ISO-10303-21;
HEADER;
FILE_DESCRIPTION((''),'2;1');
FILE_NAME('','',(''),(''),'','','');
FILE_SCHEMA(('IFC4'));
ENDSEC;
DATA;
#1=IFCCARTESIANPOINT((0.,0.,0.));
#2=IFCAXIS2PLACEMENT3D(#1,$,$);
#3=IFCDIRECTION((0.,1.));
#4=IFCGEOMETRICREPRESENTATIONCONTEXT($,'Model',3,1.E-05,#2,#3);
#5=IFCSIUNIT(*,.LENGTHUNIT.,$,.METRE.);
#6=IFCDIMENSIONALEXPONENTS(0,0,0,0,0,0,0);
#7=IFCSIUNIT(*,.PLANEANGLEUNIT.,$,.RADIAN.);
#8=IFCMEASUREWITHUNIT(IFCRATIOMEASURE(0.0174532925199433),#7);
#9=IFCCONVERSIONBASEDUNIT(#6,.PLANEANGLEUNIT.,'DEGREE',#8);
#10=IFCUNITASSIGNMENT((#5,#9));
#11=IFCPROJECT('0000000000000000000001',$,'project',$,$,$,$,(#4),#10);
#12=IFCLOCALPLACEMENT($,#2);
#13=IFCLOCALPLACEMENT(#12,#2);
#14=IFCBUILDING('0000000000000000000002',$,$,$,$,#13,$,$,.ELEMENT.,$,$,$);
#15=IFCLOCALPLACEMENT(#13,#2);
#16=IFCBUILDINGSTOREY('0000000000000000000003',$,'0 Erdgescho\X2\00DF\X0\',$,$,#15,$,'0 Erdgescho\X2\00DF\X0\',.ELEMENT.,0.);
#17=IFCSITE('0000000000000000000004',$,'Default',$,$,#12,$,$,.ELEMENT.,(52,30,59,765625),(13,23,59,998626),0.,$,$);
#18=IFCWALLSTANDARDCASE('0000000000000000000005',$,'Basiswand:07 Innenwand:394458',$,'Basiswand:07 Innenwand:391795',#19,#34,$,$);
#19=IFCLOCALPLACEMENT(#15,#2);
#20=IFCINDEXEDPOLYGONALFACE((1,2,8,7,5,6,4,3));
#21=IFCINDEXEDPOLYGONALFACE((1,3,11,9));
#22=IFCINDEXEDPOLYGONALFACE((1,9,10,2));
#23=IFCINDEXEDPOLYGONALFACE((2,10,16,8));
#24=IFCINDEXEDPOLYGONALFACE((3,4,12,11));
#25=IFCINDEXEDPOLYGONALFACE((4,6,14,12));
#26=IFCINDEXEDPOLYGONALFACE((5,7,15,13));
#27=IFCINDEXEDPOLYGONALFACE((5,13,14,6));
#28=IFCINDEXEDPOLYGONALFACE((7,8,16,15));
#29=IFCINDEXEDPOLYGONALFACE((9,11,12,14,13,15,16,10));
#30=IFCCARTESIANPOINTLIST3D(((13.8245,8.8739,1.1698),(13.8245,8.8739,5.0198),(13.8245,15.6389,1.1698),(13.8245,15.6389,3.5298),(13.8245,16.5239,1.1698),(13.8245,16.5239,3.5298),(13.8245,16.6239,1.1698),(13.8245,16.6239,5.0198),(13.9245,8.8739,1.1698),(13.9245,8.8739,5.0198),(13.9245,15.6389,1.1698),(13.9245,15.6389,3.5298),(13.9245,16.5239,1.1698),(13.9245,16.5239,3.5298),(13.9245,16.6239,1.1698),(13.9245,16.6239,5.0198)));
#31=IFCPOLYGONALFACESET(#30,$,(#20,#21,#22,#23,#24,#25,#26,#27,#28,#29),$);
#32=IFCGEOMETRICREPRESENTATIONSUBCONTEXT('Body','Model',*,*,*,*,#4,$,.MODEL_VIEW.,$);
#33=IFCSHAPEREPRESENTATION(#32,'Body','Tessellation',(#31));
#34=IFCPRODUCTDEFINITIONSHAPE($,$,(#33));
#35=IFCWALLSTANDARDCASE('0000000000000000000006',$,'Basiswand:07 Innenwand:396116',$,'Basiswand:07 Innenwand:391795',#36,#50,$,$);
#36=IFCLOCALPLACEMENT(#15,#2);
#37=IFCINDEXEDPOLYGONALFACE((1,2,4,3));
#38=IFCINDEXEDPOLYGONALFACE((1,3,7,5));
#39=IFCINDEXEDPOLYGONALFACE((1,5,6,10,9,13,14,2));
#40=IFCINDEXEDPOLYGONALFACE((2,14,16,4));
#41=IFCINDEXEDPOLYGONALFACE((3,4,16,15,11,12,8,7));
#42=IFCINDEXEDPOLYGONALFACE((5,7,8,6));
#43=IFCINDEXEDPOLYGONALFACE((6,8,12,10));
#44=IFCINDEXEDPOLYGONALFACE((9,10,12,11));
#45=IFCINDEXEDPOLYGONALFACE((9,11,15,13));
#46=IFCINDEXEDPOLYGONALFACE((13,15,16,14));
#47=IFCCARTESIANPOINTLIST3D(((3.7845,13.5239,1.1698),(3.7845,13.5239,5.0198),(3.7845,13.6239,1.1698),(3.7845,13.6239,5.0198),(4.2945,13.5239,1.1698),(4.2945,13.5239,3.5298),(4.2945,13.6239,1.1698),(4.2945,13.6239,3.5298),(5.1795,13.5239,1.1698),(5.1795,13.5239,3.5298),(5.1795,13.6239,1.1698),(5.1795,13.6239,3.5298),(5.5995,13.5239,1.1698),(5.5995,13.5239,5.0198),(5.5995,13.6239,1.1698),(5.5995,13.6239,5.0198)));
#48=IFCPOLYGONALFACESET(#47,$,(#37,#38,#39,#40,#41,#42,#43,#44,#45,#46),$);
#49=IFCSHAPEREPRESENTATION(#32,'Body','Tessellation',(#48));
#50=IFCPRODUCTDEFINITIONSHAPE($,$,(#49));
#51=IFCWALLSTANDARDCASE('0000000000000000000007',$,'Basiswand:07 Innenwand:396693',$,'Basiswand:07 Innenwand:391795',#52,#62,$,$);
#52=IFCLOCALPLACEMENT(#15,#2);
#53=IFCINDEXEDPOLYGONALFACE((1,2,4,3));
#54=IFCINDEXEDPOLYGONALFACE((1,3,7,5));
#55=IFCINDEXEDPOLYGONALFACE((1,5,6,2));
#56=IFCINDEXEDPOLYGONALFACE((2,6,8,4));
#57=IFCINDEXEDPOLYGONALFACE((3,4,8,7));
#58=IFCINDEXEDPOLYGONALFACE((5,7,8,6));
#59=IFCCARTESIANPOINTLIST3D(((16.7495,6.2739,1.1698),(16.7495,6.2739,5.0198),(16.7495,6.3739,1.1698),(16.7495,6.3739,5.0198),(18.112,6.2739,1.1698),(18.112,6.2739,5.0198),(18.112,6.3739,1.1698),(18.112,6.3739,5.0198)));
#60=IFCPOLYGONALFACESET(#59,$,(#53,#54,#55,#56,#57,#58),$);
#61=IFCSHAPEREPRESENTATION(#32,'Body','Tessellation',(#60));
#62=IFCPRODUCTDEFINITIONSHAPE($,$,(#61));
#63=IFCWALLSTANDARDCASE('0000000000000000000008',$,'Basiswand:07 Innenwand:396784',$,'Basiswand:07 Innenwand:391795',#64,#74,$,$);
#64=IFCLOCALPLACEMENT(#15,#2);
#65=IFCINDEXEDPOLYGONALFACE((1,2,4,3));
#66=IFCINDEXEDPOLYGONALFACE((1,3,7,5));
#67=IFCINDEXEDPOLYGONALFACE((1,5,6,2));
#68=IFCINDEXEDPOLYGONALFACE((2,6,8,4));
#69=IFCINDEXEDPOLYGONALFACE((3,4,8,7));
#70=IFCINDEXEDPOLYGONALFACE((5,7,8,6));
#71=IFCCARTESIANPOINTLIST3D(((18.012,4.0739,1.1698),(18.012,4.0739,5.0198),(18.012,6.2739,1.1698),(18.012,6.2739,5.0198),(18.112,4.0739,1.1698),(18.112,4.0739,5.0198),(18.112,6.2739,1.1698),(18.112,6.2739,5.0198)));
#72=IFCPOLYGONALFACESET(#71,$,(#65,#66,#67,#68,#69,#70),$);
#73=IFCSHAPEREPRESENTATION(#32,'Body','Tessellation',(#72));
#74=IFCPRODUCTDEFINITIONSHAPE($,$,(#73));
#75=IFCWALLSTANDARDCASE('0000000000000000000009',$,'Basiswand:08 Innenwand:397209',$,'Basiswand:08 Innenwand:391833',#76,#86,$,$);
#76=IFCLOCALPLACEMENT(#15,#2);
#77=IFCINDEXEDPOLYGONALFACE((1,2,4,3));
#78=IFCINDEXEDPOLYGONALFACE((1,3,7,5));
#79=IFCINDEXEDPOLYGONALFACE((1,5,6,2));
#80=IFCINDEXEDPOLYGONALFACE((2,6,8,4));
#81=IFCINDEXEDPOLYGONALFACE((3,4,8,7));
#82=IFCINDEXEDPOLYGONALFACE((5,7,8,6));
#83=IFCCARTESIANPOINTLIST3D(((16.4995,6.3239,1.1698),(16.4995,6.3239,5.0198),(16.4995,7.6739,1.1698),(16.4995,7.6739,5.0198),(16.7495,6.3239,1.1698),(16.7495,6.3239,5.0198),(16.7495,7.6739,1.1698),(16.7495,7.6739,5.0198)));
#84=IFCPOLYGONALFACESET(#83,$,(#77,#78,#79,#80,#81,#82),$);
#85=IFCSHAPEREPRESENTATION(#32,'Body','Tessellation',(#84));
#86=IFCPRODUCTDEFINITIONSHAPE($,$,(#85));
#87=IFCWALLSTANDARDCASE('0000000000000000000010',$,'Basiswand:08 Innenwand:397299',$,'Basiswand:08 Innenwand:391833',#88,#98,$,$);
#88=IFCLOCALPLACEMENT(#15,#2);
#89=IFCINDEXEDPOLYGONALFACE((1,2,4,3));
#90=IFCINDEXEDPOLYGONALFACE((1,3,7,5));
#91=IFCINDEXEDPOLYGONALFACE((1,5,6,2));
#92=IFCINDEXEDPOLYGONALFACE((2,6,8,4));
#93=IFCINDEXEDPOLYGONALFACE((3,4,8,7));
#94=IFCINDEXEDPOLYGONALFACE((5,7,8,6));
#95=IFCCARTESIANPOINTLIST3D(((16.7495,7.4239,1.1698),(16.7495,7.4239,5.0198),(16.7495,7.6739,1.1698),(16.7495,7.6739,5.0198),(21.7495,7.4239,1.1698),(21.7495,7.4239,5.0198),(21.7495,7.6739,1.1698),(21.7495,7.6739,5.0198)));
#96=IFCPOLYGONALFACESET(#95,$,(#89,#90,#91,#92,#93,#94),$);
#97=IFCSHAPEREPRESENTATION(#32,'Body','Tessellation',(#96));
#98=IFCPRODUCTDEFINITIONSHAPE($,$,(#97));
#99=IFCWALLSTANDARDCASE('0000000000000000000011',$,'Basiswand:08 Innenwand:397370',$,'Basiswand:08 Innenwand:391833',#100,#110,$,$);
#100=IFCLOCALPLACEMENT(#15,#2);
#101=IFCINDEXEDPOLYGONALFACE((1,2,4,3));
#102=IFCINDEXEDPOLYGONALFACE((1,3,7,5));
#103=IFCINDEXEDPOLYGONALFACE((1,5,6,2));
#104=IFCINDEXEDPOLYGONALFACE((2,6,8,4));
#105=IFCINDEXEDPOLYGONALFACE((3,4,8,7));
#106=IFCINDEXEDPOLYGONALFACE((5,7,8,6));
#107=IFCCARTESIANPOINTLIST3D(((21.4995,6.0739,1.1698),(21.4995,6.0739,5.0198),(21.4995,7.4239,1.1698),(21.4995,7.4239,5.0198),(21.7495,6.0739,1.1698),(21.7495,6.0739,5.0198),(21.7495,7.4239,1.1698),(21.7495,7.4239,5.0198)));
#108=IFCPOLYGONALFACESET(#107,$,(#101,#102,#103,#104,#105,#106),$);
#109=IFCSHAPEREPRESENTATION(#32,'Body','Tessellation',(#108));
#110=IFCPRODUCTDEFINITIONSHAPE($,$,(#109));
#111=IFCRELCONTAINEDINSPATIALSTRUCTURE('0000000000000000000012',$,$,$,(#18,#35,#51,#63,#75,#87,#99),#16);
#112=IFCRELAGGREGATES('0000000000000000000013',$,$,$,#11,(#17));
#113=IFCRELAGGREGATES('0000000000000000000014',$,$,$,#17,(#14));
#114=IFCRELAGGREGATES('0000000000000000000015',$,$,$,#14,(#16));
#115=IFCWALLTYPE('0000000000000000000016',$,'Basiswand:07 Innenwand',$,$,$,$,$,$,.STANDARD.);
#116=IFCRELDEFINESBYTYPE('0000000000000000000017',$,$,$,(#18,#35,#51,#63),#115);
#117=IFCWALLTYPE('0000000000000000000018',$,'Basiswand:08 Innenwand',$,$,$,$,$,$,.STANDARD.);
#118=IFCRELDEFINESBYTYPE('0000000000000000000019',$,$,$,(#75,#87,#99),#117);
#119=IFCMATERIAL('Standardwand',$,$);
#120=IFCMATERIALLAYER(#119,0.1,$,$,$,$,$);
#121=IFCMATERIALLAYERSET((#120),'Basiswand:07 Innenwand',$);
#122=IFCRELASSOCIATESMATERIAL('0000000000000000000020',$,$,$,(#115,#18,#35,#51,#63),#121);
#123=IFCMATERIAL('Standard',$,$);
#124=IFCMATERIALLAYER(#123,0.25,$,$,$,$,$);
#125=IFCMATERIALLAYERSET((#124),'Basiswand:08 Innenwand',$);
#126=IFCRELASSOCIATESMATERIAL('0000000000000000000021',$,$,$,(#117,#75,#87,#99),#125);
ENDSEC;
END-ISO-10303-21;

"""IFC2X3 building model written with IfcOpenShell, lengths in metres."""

from ifc_helpers import new_model, entity, si_unit, converted_unit, direction, frame, frame_2d, origin, place, context, subcontext, project, spatial, polyline, rectangle, extrude, clip, bounded_halfspace, material, layer, layer_set, layer_usage, type_object, element, save


model = new_model("IFC2X3")

# Units and contexts
model_context = context("Model", 3, precision=1e-05, world=origin(), true_north=direction((0.0, 1.0)))
body_context = subcontext(model_context, "Body", "Model", "MODEL_VIEW")
ifc_project = project(units=[si_unit("LENGTHUNIT", "METRE"), converted_unit("PLANEANGLEUNIT", "DEGREE", entity("IfcRatioMeasure", 0.0174532925199433), si_unit("PLANEANGLEUNIT", "RADIAN"), dimensions=[0, 0, 0, 0, 0, 0, 0])], contexts=[model_context])

# Site, building, storey
site_placement = place(None, origin())
site = spatial("IfcSite", under=ifc_project, at=site_placement, Name="Default", CompositionType="ELEMENT", RefLatitude=(52, 30, 59, 765625), RefLongitude=(13, 23, 59, 998626), RefElevation=0.0)
building_placement = place(site_placement, origin())
building = spatial("IfcBuilding", under=site, at=building_placement, CompositionType="ELEMENT")
storey_placement = place(building_placement, origin())
storey = spatial("IfcBuildingStorey", under=building, at=storey_placement, Name="0 Erdgeschoß", LongName="0 Erdgeschoß", CompositionType="ELEMENT", Elevation=0.0)

# Shared definitions
ifc_material_1 = material(Name="Standardwand")
ifc_layer_1 = layer(ifc_material_1, 0.1)
ifc_layer_set_1 = layer_set([ifc_layer_1], Name="Basiswand:07 Innenwand")
wall_type_1 = type_object("IfcWallType", Name="Basiswand:07 Innenwand", PredefinedType="STANDARD", material=ifc_layer_set_1)

# Walls, openings
ifc_layer_usage_1 = layer_usage(ifc_layer_set_1, "AXIS2", "NEGATIVE", 0.05)
wall_1_placement = place(storey_placement, frame((13.8745, 8.8739, 1.1698), z_axis=(0.0, 0.0, 1.0), x_axis=(0.0, 1.0, 0.0)))
wall_1 = element("IfcWallStandardCase", 1, at=wall_1_placement, inside=storey, type_object=wall_type_1, material=ifc_layer_usage_1, Name="Basiswand:07 Innenwand:394458", ObjectType="Basiswand:07 Innenwand:391795", context=body_context, shape_type="Clipping", body=[
    clip(extrude(rectangle(XDim=7.75, YDim=0.1, at=frame_2d((3.875, 0.0), x_axis=(-1.0, 0.0))), origin(), (0.0, 0.0, 1.0), 3.85), bounded_halfspace(frame((0.0, -0.05, 3.85), z_axis=(0.0, 0.0, -1.0), x_axis=(-1.0, 0.0, 0.0)), True, frame((0.0, -0.05, 3.85)), polyline([(0.0, 0.0), (7.75, 0.0), (7.75, 0.1), (0.0, 0.1), (0.0, 0.0)]))),
])
opening_1_placement = place(wall_1_placement, frame((6.765, -0.05, 0.0)))
element("IfcOpeningElement", 2, at=opening_1_placement, cuts=wall_1, ObjectType="Opening", context=body_context, shape_type="SweptSolid", body=[
    extrude(rectangle(XDim=2.36, YDim=0.885, at=frame_2d((1.18, 0.4425), x_axis=(1.0, 0.0))), frame((0.0, 0.0, 0.0), z_axis=(0.0, 1.0, 0.0), x_axis=(0.0, 0.0, 1.0)), (0.0, 0.0, 1.0), 0.1),
])
ifc_layer_usage_2 = layer_usage(ifc_layer_set_1, "AXIS2", "POSITIVE", -0.05)
wall_2_placement = place(storey_placement, frame((3.7845, 13.5739, 1.1698), z_axis=(0.0, 0.0, 1.0), x_axis=(1.0, 0.0, 0.0)))
wall_2 = element("IfcWallStandardCase", 3, at=wall_2_placement, inside=storey, type_object=wall_type_1, material=ifc_layer_usage_2, Name="Basiswand:07 Innenwand:396116", ObjectType="Basiswand:07 Innenwand:391795", context=body_context, shape_type="Clipping", body=[
    clip(extrude(rectangle(XDim=1.815, YDim=0.1, at=frame_2d((0.9075, 0.0), x_axis=(-1.0, 0.0))), origin(), (0.0, 0.0, 1.0), 3.85), bounded_halfspace(frame((0.0, -0.05, 3.85), z_axis=(0.0, 0.0, -1.0), x_axis=(0.0, -1.0, 0.0)), True, frame((0.0, -0.05, 3.85)), polyline([(0.0, 0.0), (1.815, 0.0), (1.815, 0.1), (0.0, 0.1), (0.0, 0.0)]))),
])
opening_2_placement = place(wall_2_placement, frame((1.395, 0.05, 0.0)))
element("IfcOpeningElement", 4, at=opening_2_placement, cuts=wall_2, ObjectType="Opening", context=body_context, shape_type="SweptSolid", body=[
    extrude(rectangle(XDim=2.36, YDim=0.885, at=frame_2d((1.18, 0.4425), x_axis=(1.0, 0.0))), frame((0.0, 0.0, 0.0), z_axis=(0.0, -1.0, 0.0), x_axis=(0.0, 0.0, 1.0)), (0.0, 0.0, 1.0), 0.1),
])

# Walls
ifc_layer_usage_3 = layer_usage(ifc_layer_set_1, "AXIS2", "POSITIVE", -0.05)
wall_3_placement = place(storey_placement, frame((16.7495, 6.3239, 1.1698), z_axis=(0.0, 0.0, 1.0), x_axis=(1.0, 0.0, 0.0)))
element("IfcWallStandardCase", 5, at=wall_3_placement, inside=storey, type_object=wall_type_1, material=ifc_layer_usage_3, Name="Basiswand:07 Innenwand:396693", ObjectType="Basiswand:07 Innenwand:391795", context=body_context, shape_type="Clipping", body=[
    clip(extrude(rectangle(XDim=1.3625, YDim=0.1, at=frame_2d((0.6813, 0.0), x_axis=(-1.0, 0.0))), origin(), (0.0, 0.0, 1.0), 3.85), bounded_halfspace(frame((0.0, -0.05, 3.85), z_axis=(0.0, 0.0, -1.0), x_axis=(0.0, -1.0, 0.0)), True, frame((0.0, -0.05, 3.85)), polyline([(0.0, 0.0), (1.2625, 0.0), (1.3625, 0.0), (1.3625, 0.1), (0.0, 0.1), (0.0, 0.05), (0.0, 0.0)]))),
])
ifc_layer_usage_4 = layer_usage(ifc_layer_set_1, "AXIS2", "POSITIVE", -0.05)
wall_4_placement = place(storey_placement, frame((18.062, 6.2739, 1.1698), z_axis=(0.0, 0.0, 1.0), x_axis=(0.0, -1.0, 0.0)))
element("IfcWallStandardCase", 6, at=wall_4_placement, inside=storey, type_object=wall_type_1, material=ifc_layer_usage_4, Name="Basiswand:07 Innenwand:396784", ObjectType="Basiswand:07 Innenwand:391795", context=body_context, shape_type="Clipping", body=[
    clip(extrude(rectangle(XDim=2.2, YDim=0.1, at=frame_2d((1.1, 0.0), x_axis=(-1.0, 0.0))), origin(), (0.0, 0.0, 1.0), 3.85), bounded_halfspace(frame((0.0, -0.05, 3.85), z_axis=(0.0, 0.0, -1.0), x_axis=(1.0, 0.0, 0.0)), True, frame((0.0, -0.05, 3.85)), polyline([(0.0, 0.0), (2.2, 0.0), (2.2, 0.1), (0.0, 0.1), (0.0, 0.0)]))),
])
ifc_material_2 = material(Name="Standard")
ifc_layer_2 = layer(ifc_material_2, 0.25)
ifc_layer_set_2 = layer_set([ifc_layer_2], Name="Basiswand:08 Innenwand")
ifc_layer_usage_5 = layer_usage(ifc_layer_set_2, "AXIS2", "NEGATIVE", 0.125)
wall_type_2 = type_object("IfcWallType", Name="Basiswand:08 Innenwand", PredefinedType="STANDARD", material=ifc_layer_set_2)
wall_5_placement = place(storey_placement, frame((16.6245, 6.3239, 1.1698), z_axis=(0.0, 0.0, 1.0), x_axis=(0.0, 1.0, 0.0)))
element("IfcWallStandardCase", 7, at=wall_5_placement, inside=storey, type_object=wall_type_2, material=ifc_layer_usage_5, Name="Basiswand:08 Innenwand:397209", ObjectType="Basiswand:08 Innenwand:391833", context=body_context, shape_type="Clipping", body=[
    clip(extrude(rectangle(XDim=1.35, YDim=0.25, at=frame_2d((0.675, 0.0), x_axis=(-1.0, 0.0))), origin(), (0.0, 0.0, 1.0), 3.85), bounded_halfspace(frame((0.0, -0.125, 3.85), z_axis=(0.0, 0.0, -1.0), x_axis=(-1.0, 0.0, 0.0)), True, frame((0.0, -0.125, 3.85)), polyline([(0.0, 0.0), (0.05, 0.0), (1.1, 0.0), (1.35, 0.0), (1.35, 0.25), (0.0, 0.25), (0.0, 0.0)]))),
])
ifc_layer_usage_6 = layer_usage(ifc_layer_set_2, "AXIS2", "NEGATIVE", 0.125)
wall_6_placement = place(storey_placement, frame((16.7495, 7.5489, 1.1698), z_axis=(0.0, 0.0, 1.0), x_axis=(1.0, 0.0, 0.0)))
element("IfcWallStandardCase", 8, at=wall_6_placement, inside=storey, type_object=wall_type_2, material=ifc_layer_usage_6, Name="Basiswand:08 Innenwand:397299", ObjectType="Basiswand:08 Innenwand:391833", context=body_context, shape_type="Clipping", body=[
    clip(extrude(rectangle(XDim=5.0, YDim=0.25, at=frame_2d((2.5, 0.0), x_axis=(-1.0, 0.0))), origin(), (0.0, 0.0, 1.0), 3.85), bounded_halfspace(frame((0.0, -0.125, 3.85), z_axis=(0.0, 0.0, -1.0), x_axis=(0.0, -1.0, 0.0)), True, frame((0.0, -0.125, 3.85)), polyline([(0.0, 0.0), (4.75, 0.0), (5.0, 0.0), (5.0, 0.25), (0.0, 0.25), (0.0, 0.0)]))),
])
ifc_layer_usage_7 = layer_usage(ifc_layer_set_2, "AXIS2", "NEGATIVE", 0.125)
wall_7_placement = place(storey_placement, frame((21.6245, 7.4239, 1.1698), z_axis=(0.0, 0.0, 1.0), x_axis=(0.0, -1.0, 0.0)))
element("IfcWallStandardCase", 9, at=wall_7_placement, inside=storey, type_object=wall_type_2, material=ifc_layer_usage_7, Name="Basiswand:08 Innenwand:397370", ObjectType="Basiswand:08 Innenwand:391833", context=body_context, shape_type="Clipping", body=[
    clip(extrude(rectangle(XDim=1.35, YDim=0.25, at=frame_2d((0.675, 0.0), x_axis=(-1.0, 0.0))), origin(), (0.0, 0.0, 1.0), 3.85), bounded_halfspace(frame((0.0, -0.125, 3.85), z_axis=(0.0, 0.0, -1.0), x_axis=(1.0, 0.0, 0.0)), True, frame((0.0, -0.125, 3.85)), polyline([(0.0, 0.0), (1.35, 0.0), (1.35, 0.25), (1.1, 0.25), (0.0, 0.25), (0.0, 0.0)]))),
])

save(model, "model.ifc")
